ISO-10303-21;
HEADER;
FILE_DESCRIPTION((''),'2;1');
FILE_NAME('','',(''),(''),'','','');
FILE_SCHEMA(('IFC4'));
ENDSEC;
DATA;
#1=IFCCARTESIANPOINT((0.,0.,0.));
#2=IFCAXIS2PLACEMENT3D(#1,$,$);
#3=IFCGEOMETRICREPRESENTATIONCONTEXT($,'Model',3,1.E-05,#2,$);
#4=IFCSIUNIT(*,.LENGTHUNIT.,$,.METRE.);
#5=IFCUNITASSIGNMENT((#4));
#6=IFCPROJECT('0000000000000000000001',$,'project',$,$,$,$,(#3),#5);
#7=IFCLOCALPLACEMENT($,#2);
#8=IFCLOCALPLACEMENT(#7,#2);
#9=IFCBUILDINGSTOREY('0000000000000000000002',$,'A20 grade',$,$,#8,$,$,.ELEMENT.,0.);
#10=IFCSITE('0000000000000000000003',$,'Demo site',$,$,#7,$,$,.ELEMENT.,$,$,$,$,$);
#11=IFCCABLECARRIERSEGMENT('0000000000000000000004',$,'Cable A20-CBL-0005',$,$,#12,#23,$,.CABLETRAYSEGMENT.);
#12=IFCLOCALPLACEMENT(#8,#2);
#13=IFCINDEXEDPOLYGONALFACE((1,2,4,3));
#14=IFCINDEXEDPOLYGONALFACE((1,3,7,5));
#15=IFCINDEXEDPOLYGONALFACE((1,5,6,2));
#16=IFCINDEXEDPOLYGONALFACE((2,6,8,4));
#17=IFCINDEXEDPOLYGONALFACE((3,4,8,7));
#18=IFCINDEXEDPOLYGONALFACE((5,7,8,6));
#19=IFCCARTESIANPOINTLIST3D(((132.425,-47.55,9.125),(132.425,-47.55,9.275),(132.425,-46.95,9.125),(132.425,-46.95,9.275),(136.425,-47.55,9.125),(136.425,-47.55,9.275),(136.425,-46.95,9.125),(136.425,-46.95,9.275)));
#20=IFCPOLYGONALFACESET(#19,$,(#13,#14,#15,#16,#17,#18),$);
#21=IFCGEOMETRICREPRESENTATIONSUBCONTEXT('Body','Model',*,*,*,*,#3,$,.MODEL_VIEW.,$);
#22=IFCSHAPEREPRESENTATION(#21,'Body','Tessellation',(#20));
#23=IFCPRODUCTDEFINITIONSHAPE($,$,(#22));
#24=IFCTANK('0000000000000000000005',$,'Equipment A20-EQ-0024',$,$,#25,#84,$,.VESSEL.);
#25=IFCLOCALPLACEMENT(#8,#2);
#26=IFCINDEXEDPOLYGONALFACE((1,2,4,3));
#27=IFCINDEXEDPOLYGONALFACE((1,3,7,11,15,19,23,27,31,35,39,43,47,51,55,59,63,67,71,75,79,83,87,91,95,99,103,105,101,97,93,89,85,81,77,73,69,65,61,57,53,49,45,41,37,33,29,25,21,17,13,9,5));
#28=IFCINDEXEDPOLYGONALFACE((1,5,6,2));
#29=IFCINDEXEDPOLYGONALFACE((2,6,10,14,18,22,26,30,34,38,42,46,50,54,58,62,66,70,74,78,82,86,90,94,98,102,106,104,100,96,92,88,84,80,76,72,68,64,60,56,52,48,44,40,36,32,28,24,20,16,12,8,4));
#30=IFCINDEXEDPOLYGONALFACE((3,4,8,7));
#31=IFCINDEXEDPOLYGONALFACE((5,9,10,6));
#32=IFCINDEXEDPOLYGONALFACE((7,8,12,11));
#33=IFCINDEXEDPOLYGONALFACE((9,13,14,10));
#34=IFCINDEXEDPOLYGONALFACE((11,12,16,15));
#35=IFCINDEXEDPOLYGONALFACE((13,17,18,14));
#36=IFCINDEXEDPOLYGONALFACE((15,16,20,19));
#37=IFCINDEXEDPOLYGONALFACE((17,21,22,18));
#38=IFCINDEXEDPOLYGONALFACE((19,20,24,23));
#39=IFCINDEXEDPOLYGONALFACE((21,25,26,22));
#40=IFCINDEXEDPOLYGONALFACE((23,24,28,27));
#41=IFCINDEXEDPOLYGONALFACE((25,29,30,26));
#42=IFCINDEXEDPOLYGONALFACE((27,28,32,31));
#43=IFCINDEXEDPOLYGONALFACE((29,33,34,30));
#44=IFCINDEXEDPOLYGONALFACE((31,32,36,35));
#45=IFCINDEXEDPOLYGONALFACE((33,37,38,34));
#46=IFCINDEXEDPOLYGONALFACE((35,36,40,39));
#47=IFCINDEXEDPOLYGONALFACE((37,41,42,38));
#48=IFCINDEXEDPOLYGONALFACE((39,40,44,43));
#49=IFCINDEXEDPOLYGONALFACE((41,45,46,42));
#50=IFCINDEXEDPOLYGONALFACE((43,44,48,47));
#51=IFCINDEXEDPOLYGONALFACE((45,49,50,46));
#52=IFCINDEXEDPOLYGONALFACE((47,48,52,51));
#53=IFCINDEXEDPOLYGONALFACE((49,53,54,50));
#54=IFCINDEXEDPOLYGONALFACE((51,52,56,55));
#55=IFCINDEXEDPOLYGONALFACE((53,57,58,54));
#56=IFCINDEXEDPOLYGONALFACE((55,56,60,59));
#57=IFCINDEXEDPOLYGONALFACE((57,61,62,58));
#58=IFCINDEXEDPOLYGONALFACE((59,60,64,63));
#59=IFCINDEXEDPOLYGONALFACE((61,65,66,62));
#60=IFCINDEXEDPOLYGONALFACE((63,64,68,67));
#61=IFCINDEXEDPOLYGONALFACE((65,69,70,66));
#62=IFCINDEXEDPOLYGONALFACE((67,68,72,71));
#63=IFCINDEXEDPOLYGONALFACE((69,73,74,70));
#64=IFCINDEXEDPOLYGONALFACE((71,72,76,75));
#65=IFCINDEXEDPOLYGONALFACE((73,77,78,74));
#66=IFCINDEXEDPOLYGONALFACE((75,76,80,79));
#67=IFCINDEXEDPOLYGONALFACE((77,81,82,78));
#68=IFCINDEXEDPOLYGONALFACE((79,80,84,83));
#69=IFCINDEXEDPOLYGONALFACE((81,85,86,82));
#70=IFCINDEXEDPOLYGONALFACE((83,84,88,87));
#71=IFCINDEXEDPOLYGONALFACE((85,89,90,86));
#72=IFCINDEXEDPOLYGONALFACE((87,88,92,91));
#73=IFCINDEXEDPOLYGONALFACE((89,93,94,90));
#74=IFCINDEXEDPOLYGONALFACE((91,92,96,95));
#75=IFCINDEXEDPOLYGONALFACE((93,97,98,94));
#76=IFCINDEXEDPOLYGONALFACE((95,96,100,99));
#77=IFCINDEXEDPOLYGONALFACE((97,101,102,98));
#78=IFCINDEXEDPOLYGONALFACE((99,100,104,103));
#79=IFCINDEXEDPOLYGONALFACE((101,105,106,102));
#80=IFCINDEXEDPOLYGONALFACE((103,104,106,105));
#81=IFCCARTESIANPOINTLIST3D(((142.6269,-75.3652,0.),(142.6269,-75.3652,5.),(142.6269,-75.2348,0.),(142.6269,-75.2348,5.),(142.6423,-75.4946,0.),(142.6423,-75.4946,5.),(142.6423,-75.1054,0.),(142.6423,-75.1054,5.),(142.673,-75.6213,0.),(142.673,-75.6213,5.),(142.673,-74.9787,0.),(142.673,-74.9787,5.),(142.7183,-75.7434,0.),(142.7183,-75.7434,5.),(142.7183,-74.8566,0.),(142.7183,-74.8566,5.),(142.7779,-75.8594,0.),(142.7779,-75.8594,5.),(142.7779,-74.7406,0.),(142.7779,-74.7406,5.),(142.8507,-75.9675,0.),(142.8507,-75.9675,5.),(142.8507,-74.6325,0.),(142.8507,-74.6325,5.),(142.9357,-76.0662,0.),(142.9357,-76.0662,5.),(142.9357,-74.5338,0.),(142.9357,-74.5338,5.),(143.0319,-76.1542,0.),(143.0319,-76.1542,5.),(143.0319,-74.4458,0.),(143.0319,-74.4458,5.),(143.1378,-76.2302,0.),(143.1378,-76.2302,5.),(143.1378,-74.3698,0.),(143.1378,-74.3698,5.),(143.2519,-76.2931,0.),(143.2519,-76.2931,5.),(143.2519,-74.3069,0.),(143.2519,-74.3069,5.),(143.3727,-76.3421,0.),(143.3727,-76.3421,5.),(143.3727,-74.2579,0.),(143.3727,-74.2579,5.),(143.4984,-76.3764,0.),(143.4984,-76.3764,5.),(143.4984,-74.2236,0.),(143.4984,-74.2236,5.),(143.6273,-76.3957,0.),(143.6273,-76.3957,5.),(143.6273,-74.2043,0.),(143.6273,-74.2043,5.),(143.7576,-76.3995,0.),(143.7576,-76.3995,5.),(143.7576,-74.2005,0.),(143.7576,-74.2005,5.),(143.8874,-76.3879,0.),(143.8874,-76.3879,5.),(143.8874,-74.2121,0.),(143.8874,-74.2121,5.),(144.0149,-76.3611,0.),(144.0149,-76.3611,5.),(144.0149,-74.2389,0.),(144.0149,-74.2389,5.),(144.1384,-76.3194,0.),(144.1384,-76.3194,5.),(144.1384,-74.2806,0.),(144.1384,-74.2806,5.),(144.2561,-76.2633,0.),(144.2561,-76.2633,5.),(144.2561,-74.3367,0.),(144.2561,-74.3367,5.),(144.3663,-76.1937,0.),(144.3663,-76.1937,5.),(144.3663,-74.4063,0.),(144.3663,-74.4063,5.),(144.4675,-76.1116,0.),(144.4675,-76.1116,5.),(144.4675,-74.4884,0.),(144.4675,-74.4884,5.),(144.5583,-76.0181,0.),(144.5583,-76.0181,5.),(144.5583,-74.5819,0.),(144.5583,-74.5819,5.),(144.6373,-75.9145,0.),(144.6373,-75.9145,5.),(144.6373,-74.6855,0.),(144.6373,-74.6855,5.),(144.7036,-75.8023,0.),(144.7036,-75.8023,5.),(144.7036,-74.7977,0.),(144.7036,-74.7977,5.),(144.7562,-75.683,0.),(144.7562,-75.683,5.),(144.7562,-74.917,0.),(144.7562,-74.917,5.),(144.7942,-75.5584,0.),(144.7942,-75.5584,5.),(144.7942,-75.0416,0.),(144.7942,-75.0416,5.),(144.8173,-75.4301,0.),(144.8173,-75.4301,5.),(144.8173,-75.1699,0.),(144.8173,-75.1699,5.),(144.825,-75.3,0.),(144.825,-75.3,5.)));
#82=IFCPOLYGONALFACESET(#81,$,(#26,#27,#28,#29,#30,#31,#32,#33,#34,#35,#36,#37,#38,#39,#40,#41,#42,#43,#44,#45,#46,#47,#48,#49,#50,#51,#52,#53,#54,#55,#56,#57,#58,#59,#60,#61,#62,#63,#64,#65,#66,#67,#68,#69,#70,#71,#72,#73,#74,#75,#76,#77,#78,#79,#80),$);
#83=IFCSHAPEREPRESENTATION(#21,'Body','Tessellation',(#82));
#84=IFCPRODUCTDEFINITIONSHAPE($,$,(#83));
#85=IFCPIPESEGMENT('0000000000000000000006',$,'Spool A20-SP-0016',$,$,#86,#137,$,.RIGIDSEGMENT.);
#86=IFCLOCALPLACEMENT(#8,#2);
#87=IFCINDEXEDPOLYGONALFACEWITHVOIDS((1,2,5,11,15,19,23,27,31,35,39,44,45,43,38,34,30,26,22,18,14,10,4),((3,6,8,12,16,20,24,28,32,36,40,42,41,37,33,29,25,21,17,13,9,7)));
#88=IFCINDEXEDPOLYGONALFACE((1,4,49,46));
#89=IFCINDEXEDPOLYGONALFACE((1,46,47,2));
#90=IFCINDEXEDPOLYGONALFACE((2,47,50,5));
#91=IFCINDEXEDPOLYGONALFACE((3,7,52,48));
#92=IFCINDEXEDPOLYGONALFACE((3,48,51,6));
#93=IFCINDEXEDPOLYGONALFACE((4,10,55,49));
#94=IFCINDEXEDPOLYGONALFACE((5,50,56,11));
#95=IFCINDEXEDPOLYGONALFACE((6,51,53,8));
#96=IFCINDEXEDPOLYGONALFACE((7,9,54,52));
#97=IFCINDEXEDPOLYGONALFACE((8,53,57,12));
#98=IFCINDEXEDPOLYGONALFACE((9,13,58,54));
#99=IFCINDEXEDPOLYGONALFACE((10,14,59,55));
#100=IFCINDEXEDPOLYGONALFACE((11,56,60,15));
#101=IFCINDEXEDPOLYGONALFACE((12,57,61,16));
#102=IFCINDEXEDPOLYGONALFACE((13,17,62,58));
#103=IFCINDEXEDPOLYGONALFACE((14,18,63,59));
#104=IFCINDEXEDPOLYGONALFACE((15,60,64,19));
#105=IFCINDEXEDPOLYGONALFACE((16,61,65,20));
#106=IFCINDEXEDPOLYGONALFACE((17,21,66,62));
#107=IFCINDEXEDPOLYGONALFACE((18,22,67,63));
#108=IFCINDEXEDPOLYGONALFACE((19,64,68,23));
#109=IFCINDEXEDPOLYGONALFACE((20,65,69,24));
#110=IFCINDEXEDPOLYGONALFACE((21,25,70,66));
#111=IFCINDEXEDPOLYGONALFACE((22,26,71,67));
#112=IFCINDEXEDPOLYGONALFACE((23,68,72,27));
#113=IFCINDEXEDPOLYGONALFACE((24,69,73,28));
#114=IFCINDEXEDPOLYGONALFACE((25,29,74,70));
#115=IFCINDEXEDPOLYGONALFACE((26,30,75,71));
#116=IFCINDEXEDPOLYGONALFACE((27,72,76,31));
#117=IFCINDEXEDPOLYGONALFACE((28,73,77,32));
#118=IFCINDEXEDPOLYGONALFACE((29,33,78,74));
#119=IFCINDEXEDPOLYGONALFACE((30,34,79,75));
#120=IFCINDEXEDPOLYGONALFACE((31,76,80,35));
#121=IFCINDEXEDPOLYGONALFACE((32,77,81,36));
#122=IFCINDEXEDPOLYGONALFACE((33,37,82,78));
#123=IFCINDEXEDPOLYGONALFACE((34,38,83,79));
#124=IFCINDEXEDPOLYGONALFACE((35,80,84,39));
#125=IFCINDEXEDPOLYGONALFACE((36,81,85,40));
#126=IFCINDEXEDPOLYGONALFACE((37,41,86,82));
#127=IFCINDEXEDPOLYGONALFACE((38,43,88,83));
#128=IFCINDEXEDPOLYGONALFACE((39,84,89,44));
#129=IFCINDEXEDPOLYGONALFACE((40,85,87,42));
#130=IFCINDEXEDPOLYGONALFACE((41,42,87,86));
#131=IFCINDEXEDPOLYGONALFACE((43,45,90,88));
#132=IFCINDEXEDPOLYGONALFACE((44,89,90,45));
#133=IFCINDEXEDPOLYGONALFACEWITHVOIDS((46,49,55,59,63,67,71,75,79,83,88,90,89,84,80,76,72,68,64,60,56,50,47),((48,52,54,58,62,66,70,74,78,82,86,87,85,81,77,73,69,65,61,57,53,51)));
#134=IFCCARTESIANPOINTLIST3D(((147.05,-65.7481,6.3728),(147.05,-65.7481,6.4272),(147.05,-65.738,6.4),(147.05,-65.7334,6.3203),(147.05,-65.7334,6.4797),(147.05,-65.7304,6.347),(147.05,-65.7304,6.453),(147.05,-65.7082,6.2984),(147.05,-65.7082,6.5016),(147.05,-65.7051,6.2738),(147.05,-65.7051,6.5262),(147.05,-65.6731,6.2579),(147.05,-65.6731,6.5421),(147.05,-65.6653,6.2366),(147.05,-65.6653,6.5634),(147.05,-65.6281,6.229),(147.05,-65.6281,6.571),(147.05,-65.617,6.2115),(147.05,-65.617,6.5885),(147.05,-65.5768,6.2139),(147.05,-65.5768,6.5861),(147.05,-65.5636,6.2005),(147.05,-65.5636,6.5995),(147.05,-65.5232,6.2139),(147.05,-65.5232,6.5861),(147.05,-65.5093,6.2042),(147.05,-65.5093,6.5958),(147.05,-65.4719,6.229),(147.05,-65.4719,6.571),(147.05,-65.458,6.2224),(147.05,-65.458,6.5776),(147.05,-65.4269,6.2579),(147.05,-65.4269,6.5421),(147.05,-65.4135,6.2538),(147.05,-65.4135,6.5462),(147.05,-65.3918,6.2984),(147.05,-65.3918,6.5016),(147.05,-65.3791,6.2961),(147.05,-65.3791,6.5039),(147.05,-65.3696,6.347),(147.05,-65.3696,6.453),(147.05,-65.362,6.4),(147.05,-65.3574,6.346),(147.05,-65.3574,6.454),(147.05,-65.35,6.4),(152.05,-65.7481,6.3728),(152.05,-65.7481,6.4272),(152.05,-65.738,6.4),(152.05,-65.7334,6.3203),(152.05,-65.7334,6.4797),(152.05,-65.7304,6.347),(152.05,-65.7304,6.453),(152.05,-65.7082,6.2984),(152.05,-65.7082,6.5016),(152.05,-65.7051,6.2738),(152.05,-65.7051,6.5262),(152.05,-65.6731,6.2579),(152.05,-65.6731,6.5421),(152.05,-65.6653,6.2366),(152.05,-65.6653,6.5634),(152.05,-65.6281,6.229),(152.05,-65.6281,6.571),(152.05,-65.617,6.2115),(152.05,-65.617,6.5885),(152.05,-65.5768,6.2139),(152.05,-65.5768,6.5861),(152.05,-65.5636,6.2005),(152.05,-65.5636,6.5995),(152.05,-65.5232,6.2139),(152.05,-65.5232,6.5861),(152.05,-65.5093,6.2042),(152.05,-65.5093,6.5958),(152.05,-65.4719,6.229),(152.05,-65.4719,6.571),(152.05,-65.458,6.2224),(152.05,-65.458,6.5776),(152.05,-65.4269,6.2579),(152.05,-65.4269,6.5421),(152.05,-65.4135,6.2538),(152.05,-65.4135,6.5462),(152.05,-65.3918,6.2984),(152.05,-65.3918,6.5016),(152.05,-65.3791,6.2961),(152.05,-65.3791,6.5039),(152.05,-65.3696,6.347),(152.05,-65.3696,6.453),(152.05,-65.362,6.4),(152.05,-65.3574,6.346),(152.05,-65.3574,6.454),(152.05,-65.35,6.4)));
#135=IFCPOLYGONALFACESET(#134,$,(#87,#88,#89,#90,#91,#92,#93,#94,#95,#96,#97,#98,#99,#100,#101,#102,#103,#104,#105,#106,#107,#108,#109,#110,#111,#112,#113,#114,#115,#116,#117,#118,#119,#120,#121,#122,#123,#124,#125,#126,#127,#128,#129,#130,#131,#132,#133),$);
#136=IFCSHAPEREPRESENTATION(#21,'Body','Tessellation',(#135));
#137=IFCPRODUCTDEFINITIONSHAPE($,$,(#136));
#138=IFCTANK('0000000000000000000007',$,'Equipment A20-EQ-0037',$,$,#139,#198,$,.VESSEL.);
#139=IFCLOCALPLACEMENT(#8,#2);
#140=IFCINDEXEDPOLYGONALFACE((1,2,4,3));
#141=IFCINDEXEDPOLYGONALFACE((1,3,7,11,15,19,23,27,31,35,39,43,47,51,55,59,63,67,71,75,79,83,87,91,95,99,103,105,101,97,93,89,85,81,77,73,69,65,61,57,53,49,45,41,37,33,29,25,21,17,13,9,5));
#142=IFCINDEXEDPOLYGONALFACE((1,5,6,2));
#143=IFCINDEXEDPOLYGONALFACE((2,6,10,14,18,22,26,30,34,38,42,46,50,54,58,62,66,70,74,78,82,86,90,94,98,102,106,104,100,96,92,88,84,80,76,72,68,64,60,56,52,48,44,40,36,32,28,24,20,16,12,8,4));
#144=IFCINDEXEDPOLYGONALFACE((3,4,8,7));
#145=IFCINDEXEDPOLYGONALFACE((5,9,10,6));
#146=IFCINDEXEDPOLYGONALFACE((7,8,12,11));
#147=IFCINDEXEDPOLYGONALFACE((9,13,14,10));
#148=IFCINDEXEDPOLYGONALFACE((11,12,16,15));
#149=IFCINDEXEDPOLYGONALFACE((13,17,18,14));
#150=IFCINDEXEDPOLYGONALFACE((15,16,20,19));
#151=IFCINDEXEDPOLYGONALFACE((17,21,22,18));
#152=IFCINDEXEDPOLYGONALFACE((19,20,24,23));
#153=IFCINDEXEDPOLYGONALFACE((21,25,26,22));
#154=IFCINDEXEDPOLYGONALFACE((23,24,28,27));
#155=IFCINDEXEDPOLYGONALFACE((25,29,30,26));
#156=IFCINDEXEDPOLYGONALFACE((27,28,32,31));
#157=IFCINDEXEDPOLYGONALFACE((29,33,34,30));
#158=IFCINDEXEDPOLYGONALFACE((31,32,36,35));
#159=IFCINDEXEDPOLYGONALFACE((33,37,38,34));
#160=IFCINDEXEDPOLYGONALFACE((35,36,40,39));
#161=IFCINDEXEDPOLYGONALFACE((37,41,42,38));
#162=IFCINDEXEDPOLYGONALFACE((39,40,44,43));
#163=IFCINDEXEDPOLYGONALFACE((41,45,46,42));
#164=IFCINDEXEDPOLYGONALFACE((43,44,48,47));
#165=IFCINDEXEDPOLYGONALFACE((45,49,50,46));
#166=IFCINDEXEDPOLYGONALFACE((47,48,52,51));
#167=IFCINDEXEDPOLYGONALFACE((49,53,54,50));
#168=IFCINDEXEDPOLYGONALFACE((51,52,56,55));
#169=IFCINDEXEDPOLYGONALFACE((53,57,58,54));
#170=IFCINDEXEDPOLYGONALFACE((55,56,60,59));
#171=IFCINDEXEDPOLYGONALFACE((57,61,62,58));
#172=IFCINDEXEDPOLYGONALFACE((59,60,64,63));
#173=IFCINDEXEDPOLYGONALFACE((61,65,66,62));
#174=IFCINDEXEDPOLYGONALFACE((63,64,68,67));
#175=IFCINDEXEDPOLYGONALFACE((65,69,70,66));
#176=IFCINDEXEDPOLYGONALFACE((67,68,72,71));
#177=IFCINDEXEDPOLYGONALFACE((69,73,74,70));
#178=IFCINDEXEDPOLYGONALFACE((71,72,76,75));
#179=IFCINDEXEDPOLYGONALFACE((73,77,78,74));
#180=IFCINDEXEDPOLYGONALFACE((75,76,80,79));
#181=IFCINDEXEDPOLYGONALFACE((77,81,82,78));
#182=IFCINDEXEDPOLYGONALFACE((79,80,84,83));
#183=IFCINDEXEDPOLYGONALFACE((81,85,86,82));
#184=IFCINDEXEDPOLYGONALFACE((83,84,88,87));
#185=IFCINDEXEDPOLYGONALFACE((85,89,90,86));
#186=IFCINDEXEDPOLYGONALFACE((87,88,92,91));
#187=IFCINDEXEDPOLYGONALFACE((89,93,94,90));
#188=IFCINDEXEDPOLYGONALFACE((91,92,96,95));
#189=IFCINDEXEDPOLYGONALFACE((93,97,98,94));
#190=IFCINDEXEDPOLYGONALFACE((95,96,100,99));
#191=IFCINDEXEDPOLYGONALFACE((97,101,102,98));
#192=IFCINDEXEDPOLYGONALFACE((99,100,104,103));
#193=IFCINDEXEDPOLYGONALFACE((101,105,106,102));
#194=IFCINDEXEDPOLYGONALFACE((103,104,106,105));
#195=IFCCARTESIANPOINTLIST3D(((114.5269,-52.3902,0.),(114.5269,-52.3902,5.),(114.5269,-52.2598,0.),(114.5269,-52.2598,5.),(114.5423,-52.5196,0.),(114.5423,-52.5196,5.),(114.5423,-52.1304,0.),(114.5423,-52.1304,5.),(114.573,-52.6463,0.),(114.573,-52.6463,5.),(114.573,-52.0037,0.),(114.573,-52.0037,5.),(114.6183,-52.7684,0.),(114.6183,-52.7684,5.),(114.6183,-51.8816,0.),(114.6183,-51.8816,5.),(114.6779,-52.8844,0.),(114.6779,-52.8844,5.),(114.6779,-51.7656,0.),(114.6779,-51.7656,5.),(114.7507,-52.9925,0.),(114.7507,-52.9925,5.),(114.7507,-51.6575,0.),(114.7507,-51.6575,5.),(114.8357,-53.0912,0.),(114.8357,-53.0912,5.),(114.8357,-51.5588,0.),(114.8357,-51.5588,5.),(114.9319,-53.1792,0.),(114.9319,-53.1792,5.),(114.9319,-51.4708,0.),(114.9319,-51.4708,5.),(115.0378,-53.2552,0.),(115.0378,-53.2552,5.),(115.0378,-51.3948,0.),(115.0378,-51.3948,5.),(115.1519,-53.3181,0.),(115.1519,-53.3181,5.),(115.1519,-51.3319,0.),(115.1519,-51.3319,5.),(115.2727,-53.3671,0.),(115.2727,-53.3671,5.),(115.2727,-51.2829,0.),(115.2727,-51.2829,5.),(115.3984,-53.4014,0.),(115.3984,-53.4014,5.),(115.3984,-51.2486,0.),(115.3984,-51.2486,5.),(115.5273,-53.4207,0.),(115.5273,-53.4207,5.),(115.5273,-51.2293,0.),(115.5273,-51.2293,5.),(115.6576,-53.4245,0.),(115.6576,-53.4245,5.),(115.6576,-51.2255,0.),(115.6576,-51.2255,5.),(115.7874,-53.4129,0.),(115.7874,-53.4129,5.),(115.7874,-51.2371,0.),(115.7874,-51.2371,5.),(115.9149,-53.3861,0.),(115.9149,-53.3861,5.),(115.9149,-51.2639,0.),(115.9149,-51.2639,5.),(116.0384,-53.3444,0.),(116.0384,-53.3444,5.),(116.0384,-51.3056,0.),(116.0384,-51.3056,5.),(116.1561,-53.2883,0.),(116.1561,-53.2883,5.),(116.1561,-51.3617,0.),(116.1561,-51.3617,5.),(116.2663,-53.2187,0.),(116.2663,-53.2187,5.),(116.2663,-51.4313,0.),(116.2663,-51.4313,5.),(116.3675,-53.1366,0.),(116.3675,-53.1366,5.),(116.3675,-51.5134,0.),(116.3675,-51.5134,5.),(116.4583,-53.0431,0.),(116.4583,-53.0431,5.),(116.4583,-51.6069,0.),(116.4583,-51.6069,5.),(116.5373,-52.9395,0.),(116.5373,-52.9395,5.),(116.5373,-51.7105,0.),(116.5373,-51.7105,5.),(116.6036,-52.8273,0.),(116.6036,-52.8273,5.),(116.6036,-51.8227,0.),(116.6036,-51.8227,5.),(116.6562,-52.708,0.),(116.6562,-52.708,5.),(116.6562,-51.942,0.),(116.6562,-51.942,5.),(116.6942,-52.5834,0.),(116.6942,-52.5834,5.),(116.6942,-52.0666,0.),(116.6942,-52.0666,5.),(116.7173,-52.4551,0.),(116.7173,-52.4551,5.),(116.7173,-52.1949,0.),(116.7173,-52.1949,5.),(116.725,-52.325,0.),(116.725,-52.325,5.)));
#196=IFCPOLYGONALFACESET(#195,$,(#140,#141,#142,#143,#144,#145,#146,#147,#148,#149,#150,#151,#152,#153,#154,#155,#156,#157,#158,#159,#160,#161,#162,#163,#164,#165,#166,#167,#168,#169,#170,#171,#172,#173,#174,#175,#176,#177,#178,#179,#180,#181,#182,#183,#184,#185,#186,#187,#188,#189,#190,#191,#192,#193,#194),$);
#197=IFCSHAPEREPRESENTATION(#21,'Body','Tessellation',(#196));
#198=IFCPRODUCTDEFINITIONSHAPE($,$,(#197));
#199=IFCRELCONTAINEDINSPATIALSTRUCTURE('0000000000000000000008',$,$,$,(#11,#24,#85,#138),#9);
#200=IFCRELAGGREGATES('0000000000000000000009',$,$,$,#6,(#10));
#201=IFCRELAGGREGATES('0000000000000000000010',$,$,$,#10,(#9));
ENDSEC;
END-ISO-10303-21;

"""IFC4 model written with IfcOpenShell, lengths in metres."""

from ifc_helpers import new_model, si_unit, frame, origin, place, context, subcontext, project, spatial, rectangle, circle, hollow_circle, extrude, element, save


model = new_model("IFC4")

# Units and contexts
model_context = context("Model", 3, precision=1e-05, world=origin())
body_context = subcontext(model_context, "Body", "Model", "MODEL_VIEW")
ifc_project = project(units=[si_unit("LENGTHUNIT", "METRE")], contexts=[model_context])

# Site, storey
site_placement = place(None, origin())
site = spatial("IfcSite", under=ifc_project, at=site_placement, Name="Demo site", CompositionType="ELEMENT")
storey_placement = place(site_placement, origin())
storey = spatial("IfcBuildingStorey", under=site, at=storey_placement, Name="A20 grade", CompositionType="ELEMENT", Elevation=0.0)

# Cable carrier segment
for number, where, name in (
    (1, (132.425, -47.25, 9.2), "Cable A20-CBL-0005"),
):
    element("IfcCableCarrierSegment", number, at=place(storey_placement, frame(where)), inside=storey, Name=name, PredefinedType="CABLETRAYSEGMENT", context=body_context, shape_type="SweptSolid", body=[
        extrude(rectangle(XDim=0.6, YDim=0.15), frame((0.0, 0.0, 0.0), z_axis=(1.0, 0.0, 0.0), x_axis=(0.0, 1.0, 0.0)), (0.0, 0.0, 1.0), 4.0),
    ])

# Tank
tank_placement = place(storey_placement, frame((143.725, -75.3, 0.0)))
element("IfcTank", 2, at=tank_placement, inside=storey, Name="Equipment A20-EQ-0024", PredefinedType="VESSEL", context=body_context, shape_type="SweptSolid", body=[
    extrude(circle(Radius=1.1), origin(), (0.0, 0.0, 1.0), 5.0),
])

# Pipe segment
pipe_segment_placement = place(storey_placement, frame((147.05, -65.55, 6.4)))
element("IfcPipeSegment", 3, at=pipe_segment_placement, inside=storey, Name="Spool A20-SP-0016", PredefinedType="RIGIDSEGMENT", context=body_context, shape_type="SweptSolid", body=[
    extrude(hollow_circle(Radius=0.2, WallThickness=0.012), frame((0.0, 0.0, 0.0), z_axis=(1.0, 0.0, 0.0), x_axis=(0.0, 1.0, 0.0)), (0.0, 0.0, 1.0), 5.0),
])

# Tank
for number, where, name in (
    (4, (115.625, -52.325, 0.0), "Equipment A20-EQ-0037"),
):
    element("IfcTank", number, at=place(storey_placement, frame(where)), inside=storey, Name=name, PredefinedType="VESSEL", context=body_context, shape_type="SweptSolid", body=[
        extrude(circle(Radius=1.1), origin(), (0.0, 0.0, 1.0), 5.0),
    ])

save(model, "model.ifc")
